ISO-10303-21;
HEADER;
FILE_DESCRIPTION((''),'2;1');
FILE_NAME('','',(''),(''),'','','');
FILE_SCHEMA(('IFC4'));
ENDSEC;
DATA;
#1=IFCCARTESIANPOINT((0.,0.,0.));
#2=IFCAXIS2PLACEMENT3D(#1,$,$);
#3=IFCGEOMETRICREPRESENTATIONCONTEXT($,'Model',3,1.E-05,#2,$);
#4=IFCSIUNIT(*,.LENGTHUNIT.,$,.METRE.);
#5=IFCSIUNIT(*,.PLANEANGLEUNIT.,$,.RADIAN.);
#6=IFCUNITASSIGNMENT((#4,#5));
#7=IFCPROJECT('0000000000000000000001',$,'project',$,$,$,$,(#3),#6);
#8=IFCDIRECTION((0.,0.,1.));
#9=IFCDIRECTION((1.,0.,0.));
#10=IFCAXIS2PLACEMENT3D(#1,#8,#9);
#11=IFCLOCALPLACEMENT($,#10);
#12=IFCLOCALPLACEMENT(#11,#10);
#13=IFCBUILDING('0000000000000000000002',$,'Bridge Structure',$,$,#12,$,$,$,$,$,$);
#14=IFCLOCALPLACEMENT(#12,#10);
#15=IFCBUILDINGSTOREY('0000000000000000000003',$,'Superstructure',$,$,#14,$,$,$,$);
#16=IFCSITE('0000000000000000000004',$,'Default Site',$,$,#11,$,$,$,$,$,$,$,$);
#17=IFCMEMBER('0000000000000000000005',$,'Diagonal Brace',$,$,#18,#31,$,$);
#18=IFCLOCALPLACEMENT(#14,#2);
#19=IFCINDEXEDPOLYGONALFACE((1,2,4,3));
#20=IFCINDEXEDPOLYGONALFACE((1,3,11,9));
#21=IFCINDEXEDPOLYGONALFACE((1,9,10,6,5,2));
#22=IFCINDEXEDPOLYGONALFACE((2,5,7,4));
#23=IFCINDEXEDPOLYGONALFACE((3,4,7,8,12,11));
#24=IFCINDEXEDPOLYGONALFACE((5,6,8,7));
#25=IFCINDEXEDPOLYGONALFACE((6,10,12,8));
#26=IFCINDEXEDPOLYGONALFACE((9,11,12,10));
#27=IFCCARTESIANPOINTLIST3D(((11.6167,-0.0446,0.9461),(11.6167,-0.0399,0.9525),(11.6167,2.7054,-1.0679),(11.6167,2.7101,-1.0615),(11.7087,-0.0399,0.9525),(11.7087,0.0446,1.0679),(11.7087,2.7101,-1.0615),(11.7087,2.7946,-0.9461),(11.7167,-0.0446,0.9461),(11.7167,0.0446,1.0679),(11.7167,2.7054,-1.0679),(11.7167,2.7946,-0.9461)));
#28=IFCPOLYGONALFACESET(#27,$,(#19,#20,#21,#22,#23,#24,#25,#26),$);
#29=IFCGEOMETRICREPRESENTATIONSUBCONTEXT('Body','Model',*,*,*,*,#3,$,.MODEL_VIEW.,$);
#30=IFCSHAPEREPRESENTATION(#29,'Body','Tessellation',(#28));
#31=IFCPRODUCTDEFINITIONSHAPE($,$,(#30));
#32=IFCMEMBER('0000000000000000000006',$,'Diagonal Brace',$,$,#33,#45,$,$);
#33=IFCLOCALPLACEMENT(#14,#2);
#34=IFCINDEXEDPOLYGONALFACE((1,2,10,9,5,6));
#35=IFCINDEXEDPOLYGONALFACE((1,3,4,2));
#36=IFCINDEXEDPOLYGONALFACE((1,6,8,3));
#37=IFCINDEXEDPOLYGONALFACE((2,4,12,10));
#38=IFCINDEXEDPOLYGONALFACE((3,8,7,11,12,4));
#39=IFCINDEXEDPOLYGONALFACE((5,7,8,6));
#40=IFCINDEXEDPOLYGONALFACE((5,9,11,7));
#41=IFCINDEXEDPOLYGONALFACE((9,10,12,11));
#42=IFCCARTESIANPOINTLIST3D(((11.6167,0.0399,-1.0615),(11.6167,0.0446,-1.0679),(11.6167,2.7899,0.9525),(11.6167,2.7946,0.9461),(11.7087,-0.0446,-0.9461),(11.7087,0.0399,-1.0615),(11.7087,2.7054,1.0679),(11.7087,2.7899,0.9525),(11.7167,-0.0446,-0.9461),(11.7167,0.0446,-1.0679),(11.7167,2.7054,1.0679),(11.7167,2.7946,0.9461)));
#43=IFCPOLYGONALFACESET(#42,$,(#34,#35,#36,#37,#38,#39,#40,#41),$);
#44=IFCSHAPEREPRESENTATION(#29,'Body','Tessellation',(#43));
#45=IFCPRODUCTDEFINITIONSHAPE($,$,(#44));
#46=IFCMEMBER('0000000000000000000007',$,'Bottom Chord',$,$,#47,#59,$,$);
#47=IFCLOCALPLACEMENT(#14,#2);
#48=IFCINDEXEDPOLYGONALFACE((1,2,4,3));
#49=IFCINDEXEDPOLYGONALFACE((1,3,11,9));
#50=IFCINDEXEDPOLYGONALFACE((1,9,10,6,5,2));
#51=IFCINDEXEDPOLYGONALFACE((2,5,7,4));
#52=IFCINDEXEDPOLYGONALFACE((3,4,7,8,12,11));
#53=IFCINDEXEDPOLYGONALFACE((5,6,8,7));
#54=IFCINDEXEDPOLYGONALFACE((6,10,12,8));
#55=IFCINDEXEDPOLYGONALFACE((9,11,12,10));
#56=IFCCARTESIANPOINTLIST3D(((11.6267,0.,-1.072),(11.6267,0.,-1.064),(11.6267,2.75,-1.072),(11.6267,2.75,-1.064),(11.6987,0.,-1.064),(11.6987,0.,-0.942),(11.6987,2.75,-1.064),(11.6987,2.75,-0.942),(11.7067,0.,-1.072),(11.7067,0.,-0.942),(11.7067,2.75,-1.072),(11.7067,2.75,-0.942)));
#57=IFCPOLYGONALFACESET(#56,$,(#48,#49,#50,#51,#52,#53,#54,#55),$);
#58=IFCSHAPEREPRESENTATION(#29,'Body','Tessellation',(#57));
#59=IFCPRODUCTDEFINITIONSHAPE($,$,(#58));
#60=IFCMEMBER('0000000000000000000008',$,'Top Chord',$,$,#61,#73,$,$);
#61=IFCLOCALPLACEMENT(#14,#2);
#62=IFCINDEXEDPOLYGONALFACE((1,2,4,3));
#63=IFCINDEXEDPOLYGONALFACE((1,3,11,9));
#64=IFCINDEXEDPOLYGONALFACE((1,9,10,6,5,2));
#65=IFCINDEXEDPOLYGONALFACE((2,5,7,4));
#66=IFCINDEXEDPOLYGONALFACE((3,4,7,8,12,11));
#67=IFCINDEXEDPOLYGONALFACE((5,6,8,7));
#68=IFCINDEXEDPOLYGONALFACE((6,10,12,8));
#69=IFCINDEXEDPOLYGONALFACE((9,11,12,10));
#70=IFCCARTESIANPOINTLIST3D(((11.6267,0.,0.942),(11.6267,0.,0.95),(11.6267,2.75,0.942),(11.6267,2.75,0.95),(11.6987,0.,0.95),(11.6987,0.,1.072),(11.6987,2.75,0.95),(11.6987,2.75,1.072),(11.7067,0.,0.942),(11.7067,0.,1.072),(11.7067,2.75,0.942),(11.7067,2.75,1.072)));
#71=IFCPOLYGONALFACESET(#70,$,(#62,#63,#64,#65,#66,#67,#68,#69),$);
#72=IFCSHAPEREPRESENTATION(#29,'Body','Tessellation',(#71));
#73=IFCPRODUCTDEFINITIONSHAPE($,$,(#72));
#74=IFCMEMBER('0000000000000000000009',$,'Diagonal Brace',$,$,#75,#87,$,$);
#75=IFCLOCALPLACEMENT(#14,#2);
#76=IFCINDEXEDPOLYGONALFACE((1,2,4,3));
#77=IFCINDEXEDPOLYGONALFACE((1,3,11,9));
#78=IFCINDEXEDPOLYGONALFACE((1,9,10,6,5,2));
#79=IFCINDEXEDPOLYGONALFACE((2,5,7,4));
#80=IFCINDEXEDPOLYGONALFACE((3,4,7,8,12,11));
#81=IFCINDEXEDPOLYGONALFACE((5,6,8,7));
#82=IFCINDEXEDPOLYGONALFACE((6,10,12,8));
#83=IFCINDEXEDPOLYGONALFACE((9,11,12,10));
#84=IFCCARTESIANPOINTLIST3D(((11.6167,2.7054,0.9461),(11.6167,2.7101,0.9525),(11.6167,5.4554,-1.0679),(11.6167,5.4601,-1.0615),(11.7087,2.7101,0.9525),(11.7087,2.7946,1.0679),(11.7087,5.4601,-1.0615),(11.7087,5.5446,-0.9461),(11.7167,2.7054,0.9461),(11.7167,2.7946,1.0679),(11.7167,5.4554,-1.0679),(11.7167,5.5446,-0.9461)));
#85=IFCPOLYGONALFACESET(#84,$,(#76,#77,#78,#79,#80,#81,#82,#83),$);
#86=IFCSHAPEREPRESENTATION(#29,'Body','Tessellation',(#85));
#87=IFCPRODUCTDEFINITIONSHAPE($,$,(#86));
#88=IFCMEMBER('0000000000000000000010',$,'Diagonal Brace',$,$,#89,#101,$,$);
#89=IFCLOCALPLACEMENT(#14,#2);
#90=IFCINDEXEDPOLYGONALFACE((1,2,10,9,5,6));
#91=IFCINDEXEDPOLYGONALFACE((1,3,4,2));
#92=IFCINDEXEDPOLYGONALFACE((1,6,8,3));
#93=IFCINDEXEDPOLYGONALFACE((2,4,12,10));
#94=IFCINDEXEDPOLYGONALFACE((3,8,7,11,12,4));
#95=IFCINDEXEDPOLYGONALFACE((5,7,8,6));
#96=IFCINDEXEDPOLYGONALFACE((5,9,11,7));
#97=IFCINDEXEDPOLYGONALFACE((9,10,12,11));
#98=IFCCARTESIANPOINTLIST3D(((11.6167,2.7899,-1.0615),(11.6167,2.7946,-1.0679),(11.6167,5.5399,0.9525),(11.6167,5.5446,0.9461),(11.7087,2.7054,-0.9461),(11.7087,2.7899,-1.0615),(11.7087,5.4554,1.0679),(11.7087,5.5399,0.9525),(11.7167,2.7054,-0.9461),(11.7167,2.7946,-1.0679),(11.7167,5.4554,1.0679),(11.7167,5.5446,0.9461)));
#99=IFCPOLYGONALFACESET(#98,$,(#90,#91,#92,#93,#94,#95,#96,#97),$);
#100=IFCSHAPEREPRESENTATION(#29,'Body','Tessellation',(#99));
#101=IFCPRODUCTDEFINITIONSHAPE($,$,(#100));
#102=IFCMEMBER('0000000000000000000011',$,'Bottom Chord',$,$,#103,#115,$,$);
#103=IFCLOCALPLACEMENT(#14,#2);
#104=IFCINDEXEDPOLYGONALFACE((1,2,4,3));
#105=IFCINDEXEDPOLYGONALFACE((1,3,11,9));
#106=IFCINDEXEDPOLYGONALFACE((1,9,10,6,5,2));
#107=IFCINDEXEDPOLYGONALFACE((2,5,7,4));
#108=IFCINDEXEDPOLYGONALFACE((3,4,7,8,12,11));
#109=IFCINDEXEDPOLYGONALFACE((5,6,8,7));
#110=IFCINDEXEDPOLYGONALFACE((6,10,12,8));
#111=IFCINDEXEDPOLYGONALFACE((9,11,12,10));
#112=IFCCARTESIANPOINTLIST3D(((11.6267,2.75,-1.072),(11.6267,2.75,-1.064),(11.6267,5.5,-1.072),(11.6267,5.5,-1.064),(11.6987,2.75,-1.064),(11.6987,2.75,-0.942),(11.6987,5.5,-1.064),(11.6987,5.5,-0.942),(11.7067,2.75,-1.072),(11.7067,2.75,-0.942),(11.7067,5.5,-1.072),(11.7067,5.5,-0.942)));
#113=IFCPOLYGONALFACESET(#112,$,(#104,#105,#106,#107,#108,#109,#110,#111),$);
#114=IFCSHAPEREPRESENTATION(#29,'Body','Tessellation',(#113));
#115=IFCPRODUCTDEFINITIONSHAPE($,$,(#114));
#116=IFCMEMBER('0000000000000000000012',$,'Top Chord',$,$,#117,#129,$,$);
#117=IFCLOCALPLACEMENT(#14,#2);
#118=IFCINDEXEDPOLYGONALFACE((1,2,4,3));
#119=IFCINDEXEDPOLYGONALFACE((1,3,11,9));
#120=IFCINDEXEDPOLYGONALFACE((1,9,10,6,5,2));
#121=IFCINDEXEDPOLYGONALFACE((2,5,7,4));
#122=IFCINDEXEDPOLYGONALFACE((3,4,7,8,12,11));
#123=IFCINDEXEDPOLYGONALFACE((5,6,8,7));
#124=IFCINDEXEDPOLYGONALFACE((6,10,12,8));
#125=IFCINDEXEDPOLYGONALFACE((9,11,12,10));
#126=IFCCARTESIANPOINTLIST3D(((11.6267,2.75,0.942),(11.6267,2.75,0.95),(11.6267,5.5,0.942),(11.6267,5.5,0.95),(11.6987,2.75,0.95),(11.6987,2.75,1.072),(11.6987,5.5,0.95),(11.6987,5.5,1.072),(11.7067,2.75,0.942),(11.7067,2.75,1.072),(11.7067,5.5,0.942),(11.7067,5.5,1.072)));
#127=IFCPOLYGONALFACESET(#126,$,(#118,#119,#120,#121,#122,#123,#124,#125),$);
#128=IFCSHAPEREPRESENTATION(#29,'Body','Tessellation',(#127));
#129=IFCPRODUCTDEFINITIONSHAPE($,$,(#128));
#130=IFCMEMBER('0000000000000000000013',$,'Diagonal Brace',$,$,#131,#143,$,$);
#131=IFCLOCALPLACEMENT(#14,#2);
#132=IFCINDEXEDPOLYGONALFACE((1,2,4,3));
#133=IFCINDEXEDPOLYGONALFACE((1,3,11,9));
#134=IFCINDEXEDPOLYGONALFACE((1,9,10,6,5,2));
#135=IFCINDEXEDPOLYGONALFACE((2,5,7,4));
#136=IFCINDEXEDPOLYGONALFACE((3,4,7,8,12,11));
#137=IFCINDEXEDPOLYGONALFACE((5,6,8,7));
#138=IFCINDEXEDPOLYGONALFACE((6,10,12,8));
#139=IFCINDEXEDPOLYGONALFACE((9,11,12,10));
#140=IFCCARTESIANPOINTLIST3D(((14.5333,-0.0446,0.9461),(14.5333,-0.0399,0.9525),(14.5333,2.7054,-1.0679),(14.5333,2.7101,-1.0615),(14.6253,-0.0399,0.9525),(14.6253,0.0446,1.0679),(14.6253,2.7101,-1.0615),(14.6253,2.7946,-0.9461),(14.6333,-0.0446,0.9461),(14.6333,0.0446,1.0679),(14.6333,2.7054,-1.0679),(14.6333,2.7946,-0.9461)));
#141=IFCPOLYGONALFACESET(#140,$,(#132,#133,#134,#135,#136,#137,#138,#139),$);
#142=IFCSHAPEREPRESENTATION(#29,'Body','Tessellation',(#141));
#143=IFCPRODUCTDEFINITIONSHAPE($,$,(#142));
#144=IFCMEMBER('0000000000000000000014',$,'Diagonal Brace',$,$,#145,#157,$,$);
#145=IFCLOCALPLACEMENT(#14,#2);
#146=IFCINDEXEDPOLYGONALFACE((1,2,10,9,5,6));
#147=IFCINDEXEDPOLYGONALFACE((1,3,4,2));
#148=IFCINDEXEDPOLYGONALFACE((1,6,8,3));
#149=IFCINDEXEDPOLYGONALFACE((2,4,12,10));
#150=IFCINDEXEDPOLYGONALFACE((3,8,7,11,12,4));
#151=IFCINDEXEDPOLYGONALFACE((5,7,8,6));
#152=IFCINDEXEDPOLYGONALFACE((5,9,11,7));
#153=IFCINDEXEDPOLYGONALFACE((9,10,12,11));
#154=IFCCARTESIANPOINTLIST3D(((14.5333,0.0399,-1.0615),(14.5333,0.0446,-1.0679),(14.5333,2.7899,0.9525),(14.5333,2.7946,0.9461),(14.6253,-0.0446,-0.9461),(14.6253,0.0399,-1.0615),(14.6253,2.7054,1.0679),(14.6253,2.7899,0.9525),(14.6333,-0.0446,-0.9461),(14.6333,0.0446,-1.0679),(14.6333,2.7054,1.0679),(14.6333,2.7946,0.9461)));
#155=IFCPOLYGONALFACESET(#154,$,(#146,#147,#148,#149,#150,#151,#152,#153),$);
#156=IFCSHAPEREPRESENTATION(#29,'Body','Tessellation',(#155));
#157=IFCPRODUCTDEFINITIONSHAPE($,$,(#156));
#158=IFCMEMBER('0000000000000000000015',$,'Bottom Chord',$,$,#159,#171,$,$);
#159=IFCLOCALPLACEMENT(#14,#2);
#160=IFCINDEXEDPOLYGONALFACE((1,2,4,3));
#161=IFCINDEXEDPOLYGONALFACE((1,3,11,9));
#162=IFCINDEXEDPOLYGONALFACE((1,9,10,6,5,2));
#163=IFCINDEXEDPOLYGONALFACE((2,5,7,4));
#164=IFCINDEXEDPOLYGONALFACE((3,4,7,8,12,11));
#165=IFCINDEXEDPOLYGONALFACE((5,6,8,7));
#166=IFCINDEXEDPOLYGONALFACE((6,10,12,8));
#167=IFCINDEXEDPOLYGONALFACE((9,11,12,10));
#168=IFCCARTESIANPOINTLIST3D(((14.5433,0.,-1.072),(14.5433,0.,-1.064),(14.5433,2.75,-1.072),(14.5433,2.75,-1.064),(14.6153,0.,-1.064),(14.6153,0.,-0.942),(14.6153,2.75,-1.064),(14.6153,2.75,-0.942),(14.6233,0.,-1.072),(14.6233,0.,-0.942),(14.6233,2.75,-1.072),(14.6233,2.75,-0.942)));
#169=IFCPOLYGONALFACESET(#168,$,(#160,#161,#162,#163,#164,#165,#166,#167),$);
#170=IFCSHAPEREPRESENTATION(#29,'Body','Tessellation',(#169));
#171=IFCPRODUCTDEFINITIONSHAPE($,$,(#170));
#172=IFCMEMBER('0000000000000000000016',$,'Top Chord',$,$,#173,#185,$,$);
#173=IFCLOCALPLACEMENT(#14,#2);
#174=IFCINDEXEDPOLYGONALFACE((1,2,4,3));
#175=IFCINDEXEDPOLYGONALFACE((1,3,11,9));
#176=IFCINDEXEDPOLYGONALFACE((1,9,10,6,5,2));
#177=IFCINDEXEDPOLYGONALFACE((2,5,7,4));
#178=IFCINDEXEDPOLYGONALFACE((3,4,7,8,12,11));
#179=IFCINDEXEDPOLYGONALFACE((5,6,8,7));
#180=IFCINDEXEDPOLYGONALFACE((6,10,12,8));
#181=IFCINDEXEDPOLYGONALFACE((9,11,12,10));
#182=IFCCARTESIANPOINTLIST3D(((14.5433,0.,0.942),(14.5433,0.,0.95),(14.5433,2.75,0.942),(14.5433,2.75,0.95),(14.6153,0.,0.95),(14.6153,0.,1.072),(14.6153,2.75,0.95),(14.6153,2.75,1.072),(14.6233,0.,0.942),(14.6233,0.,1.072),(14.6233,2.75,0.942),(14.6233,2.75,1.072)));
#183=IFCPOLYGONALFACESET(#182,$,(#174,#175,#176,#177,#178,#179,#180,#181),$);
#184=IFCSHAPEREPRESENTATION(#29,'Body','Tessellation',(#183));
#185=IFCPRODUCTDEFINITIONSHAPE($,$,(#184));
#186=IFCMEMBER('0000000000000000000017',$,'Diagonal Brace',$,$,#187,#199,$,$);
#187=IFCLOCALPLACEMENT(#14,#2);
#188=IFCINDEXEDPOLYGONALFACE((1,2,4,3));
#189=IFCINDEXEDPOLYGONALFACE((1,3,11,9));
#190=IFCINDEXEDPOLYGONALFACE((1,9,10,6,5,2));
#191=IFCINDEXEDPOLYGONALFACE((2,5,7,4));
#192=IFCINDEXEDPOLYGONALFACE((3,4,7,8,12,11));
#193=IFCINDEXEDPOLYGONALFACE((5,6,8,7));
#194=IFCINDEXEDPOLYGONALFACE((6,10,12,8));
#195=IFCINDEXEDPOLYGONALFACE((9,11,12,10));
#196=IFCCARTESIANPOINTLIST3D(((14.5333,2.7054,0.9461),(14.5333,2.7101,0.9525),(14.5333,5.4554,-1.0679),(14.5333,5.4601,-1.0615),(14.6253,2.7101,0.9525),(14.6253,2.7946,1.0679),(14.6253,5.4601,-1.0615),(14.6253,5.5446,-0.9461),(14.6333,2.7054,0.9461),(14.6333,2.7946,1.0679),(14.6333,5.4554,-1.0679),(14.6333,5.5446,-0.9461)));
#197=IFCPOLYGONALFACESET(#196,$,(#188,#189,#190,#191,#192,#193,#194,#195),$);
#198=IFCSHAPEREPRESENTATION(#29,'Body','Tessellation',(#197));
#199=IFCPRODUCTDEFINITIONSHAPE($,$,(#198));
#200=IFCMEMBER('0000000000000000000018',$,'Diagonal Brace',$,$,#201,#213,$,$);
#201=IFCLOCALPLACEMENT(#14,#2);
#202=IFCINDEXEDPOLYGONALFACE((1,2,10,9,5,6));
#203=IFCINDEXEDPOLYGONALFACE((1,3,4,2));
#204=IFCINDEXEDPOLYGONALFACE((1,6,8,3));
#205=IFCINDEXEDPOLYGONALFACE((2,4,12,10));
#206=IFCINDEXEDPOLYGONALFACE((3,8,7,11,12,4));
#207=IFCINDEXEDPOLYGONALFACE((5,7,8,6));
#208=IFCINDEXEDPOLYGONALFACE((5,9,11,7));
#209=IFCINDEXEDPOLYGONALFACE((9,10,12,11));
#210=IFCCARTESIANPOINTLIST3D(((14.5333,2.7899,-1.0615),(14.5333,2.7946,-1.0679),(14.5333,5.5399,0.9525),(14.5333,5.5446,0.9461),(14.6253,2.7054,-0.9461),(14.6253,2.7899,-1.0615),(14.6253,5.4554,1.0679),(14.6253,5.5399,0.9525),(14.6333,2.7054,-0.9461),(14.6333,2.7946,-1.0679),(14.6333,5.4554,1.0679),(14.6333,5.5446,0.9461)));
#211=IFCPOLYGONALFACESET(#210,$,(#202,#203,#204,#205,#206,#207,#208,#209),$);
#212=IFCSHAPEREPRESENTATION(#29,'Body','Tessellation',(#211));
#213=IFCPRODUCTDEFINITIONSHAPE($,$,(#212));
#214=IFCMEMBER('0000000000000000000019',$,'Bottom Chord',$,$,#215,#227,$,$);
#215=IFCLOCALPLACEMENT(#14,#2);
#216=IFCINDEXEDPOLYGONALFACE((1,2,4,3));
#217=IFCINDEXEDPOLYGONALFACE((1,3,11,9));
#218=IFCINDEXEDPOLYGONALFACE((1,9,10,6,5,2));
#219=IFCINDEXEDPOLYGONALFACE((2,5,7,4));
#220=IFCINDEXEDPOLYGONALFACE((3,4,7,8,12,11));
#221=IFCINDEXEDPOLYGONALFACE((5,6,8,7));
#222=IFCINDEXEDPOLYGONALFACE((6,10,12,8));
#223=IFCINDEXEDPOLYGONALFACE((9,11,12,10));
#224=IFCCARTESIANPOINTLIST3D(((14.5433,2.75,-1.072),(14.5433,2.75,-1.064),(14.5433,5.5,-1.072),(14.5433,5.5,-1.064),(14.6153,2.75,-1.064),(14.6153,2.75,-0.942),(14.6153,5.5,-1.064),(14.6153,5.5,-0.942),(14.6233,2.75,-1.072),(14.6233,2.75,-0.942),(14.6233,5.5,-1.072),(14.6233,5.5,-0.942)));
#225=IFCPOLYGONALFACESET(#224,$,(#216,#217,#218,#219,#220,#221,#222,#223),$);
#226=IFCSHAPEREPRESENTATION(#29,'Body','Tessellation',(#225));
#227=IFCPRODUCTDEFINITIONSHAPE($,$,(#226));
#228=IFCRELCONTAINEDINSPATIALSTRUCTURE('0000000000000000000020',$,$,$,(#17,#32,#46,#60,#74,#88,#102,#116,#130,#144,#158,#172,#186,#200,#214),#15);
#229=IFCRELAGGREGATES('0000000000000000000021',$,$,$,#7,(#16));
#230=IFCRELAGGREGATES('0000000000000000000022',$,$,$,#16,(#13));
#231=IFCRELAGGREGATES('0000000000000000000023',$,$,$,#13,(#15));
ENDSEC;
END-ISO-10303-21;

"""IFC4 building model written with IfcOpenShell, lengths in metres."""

from ifc_helpers import new_model, si_unit, frame, origin, origin_with_axes, origin_2d_with_axis, place, context, subcontext, project, spatial, l_section, extrude, element, save


model = new_model("IFC4")

# Units and contexts
model_context = context("Model", 3, precision=1e-05, world=origin())
body_context = subcontext(model_context, "Body", "Model", "MODEL_VIEW")
ifc_project = project(units=[si_unit("LENGTHUNIT", "METRE"), si_unit("PLANEANGLEUNIT", "RADIAN")], contexts=[model_context])

# Site, building, storey
site_placement = place(None, origin_with_axes())
site = spatial("IfcSite", under=ifc_project, at=site_placement, Name="Default Site")
building_placement = place(site_placement, origin_with_axes())
building = spatial("IfcBuilding", under=site, at=building_placement, Name="Bridge Structure")
storey_placement = place(building_placement, origin_with_axes())
storey = spatial("IfcBuildingStorey", under=building, at=storey_placement, Name="Superstructure")

# Members
for number, where, z_axis, x_axis, name in (
    (1, (11.6667, 0.0, 1.007), (0.0, 0.806778, -0.590855), (-1.0, 0.0, 0.0), "Diagonal Brace"),
    (2, (11.6667, 0.0, -1.007), (0.0, 0.806778, 0.590855), (-1.0, 0.0, 0.0), "Diagonal Brace"),
):
    element("IfcMember", number, at=place(storey_placement, frame(where, z_axis=z_axis, x_axis=x_axis)), inside=storey, Name=name, context=body_context, shape_type="SweptSolid", body=[
        extrude(l_section(Depth=0.151, Width=0.1, Thickness=0.008, at=origin_2d_with_axis()), origin_with_axes(), (0.0, 0.0, 1.0), 3.4086),
    ])
for number, where, z_axis, x_axis, name in (
    (3, (11.6667, 0.0, -1.007), (0.0, 1.0, 0.0), (-1.0, 0.0, 0.0), "Bottom Chord"),
    (4, (11.6667, 0.0, 1.007), (0.0, 1.0, 0.0), (-1.0, 0.0, 0.0), "Top Chord"),
):
    element("IfcMember", number, at=place(storey_placement, frame(where, z_axis=z_axis, x_axis=x_axis)), inside=storey, Name=name, context=body_context, shape_type="SweptSolid", body=[
        extrude(l_section(Depth=0.13, Width=0.08, Thickness=0.008, at=origin_2d_with_axis()), origin_with_axes(), (0.0, 0.0, 1.0), 2.75),
    ])
for number, where, z_axis, x_axis, name in (
    (5, (11.6667, 2.75, 1.007), (0.0, 0.806778, -0.590855), (-1.0, 0.0, 0.0), "Diagonal Brace"),
    (6, (11.6667, 2.75, -1.007), (0.0, 0.806778, 0.590855), (-1.0, 0.0, 0.0), "Diagonal Brace"),
):
    element("IfcMember", number, at=place(storey_placement, frame(where, z_axis=z_axis, x_axis=x_axis)), inside=storey, Name=name, context=body_context, shape_type="SweptSolid", body=[
        extrude(l_section(Depth=0.151, Width=0.1, Thickness=0.008, at=origin_2d_with_axis()), origin_with_axes(), (0.0, 0.0, 1.0), 3.4086),
    ])
for number, where, z_axis, x_axis, name in (
    (7, (11.6667, 2.75, -1.007), (0.0, 1.0, 0.0), (-1.0, 0.0, 0.0), "Bottom Chord"),
    (8, (11.6667, 2.75, 1.007), (0.0, 1.0, 0.0), (-1.0, 0.0, 0.0), "Top Chord"),
):
    element("IfcMember", number, at=place(storey_placement, frame(where, z_axis=z_axis, x_axis=x_axis)), inside=storey, Name=name, context=body_context, shape_type="SweptSolid", body=[
        extrude(l_section(Depth=0.13, Width=0.08, Thickness=0.008, at=origin_2d_with_axis()), origin_with_axes(), (0.0, 0.0, 1.0), 2.75),
    ])
for number, where, z_axis, x_axis, name in (
    (9, (14.5833, 0.0, 1.007), (0.0, 0.806778, -0.590855), (-1.0, 0.0, 0.0), "Diagonal Brace"),
    (10, (14.5833, 0.0, -1.007), (0.0, 0.806778, 0.590855), (-1.0, 0.0, 0.0), "Diagonal Brace"),
):
    element("IfcMember", number, at=place(storey_placement, frame(where, z_axis=z_axis, x_axis=x_axis)), inside=storey, Name=name, context=body_context, shape_type="SweptSolid", body=[
        extrude(l_section(Depth=0.151, Width=0.1, Thickness=0.008, at=origin_2d_with_axis()), origin_with_axes(), (0.0, 0.0, 1.0), 3.4086),
    ])
for number, where, z_axis, x_axis, name in (
    (11, (14.5833, 0.0, -1.007), (0.0, 1.0, 0.0), (-1.0, 0.0, 0.0), "Bottom Chord"),
    (12, (14.5833, 0.0, 1.007), (0.0, 1.0, 0.0), (-1.0, 0.0, 0.0), "Top Chord"),
):
    element("IfcMember", number, at=place(storey_placement, frame(where, z_axis=z_axis, x_axis=x_axis)), inside=storey, Name=name, context=body_context, shape_type="SweptSolid", body=[
        extrude(l_section(Depth=0.13, Width=0.08, Thickness=0.008, at=origin_2d_with_axis()), origin_with_axes(), (0.0, 0.0, 1.0), 2.75),
    ])
for number, where, z_axis, x_axis, name in (
    (13, (14.5833, 2.75, 1.007), (0.0, 0.806778, -0.590855), (-1.0, 0.0, 0.0), "Diagonal Brace"),
    (14, (14.5833, 2.75, -1.007), (0.0, 0.806778, 0.590855), (-1.0, 0.0, 0.0), "Diagonal Brace"),
):
    element("IfcMember", number, at=place(storey_placement, frame(where, z_axis=z_axis, x_axis=x_axis)), inside=storey, Name=name, context=body_context, shape_type="SweptSolid", body=[
        extrude(l_section(Depth=0.151, Width=0.1, Thickness=0.008, at=origin_2d_with_axis()), origin_with_axes(), (0.0, 0.0, 1.0), 3.4086),
    ])
for number, where, z_axis, x_axis, name in (
    (15, (14.5833, 2.75, -1.007), (0.0, 1.0, 0.0), (-1.0, 0.0, 0.0), "Bottom Chord"),
):
    element("IfcMember", number, at=place(storey_placement, frame(where, z_axis=z_axis, x_axis=x_axis)), inside=storey, Name=name, context=body_context, shape_type="SweptSolid", body=[
        extrude(l_section(Depth=0.13, Width=0.08, Thickness=0.008, at=origin_2d_with_axis()), origin_with_axes(), (0.0, 0.0, 1.0), 2.75),
    ])

save(model, "model.ifc")
